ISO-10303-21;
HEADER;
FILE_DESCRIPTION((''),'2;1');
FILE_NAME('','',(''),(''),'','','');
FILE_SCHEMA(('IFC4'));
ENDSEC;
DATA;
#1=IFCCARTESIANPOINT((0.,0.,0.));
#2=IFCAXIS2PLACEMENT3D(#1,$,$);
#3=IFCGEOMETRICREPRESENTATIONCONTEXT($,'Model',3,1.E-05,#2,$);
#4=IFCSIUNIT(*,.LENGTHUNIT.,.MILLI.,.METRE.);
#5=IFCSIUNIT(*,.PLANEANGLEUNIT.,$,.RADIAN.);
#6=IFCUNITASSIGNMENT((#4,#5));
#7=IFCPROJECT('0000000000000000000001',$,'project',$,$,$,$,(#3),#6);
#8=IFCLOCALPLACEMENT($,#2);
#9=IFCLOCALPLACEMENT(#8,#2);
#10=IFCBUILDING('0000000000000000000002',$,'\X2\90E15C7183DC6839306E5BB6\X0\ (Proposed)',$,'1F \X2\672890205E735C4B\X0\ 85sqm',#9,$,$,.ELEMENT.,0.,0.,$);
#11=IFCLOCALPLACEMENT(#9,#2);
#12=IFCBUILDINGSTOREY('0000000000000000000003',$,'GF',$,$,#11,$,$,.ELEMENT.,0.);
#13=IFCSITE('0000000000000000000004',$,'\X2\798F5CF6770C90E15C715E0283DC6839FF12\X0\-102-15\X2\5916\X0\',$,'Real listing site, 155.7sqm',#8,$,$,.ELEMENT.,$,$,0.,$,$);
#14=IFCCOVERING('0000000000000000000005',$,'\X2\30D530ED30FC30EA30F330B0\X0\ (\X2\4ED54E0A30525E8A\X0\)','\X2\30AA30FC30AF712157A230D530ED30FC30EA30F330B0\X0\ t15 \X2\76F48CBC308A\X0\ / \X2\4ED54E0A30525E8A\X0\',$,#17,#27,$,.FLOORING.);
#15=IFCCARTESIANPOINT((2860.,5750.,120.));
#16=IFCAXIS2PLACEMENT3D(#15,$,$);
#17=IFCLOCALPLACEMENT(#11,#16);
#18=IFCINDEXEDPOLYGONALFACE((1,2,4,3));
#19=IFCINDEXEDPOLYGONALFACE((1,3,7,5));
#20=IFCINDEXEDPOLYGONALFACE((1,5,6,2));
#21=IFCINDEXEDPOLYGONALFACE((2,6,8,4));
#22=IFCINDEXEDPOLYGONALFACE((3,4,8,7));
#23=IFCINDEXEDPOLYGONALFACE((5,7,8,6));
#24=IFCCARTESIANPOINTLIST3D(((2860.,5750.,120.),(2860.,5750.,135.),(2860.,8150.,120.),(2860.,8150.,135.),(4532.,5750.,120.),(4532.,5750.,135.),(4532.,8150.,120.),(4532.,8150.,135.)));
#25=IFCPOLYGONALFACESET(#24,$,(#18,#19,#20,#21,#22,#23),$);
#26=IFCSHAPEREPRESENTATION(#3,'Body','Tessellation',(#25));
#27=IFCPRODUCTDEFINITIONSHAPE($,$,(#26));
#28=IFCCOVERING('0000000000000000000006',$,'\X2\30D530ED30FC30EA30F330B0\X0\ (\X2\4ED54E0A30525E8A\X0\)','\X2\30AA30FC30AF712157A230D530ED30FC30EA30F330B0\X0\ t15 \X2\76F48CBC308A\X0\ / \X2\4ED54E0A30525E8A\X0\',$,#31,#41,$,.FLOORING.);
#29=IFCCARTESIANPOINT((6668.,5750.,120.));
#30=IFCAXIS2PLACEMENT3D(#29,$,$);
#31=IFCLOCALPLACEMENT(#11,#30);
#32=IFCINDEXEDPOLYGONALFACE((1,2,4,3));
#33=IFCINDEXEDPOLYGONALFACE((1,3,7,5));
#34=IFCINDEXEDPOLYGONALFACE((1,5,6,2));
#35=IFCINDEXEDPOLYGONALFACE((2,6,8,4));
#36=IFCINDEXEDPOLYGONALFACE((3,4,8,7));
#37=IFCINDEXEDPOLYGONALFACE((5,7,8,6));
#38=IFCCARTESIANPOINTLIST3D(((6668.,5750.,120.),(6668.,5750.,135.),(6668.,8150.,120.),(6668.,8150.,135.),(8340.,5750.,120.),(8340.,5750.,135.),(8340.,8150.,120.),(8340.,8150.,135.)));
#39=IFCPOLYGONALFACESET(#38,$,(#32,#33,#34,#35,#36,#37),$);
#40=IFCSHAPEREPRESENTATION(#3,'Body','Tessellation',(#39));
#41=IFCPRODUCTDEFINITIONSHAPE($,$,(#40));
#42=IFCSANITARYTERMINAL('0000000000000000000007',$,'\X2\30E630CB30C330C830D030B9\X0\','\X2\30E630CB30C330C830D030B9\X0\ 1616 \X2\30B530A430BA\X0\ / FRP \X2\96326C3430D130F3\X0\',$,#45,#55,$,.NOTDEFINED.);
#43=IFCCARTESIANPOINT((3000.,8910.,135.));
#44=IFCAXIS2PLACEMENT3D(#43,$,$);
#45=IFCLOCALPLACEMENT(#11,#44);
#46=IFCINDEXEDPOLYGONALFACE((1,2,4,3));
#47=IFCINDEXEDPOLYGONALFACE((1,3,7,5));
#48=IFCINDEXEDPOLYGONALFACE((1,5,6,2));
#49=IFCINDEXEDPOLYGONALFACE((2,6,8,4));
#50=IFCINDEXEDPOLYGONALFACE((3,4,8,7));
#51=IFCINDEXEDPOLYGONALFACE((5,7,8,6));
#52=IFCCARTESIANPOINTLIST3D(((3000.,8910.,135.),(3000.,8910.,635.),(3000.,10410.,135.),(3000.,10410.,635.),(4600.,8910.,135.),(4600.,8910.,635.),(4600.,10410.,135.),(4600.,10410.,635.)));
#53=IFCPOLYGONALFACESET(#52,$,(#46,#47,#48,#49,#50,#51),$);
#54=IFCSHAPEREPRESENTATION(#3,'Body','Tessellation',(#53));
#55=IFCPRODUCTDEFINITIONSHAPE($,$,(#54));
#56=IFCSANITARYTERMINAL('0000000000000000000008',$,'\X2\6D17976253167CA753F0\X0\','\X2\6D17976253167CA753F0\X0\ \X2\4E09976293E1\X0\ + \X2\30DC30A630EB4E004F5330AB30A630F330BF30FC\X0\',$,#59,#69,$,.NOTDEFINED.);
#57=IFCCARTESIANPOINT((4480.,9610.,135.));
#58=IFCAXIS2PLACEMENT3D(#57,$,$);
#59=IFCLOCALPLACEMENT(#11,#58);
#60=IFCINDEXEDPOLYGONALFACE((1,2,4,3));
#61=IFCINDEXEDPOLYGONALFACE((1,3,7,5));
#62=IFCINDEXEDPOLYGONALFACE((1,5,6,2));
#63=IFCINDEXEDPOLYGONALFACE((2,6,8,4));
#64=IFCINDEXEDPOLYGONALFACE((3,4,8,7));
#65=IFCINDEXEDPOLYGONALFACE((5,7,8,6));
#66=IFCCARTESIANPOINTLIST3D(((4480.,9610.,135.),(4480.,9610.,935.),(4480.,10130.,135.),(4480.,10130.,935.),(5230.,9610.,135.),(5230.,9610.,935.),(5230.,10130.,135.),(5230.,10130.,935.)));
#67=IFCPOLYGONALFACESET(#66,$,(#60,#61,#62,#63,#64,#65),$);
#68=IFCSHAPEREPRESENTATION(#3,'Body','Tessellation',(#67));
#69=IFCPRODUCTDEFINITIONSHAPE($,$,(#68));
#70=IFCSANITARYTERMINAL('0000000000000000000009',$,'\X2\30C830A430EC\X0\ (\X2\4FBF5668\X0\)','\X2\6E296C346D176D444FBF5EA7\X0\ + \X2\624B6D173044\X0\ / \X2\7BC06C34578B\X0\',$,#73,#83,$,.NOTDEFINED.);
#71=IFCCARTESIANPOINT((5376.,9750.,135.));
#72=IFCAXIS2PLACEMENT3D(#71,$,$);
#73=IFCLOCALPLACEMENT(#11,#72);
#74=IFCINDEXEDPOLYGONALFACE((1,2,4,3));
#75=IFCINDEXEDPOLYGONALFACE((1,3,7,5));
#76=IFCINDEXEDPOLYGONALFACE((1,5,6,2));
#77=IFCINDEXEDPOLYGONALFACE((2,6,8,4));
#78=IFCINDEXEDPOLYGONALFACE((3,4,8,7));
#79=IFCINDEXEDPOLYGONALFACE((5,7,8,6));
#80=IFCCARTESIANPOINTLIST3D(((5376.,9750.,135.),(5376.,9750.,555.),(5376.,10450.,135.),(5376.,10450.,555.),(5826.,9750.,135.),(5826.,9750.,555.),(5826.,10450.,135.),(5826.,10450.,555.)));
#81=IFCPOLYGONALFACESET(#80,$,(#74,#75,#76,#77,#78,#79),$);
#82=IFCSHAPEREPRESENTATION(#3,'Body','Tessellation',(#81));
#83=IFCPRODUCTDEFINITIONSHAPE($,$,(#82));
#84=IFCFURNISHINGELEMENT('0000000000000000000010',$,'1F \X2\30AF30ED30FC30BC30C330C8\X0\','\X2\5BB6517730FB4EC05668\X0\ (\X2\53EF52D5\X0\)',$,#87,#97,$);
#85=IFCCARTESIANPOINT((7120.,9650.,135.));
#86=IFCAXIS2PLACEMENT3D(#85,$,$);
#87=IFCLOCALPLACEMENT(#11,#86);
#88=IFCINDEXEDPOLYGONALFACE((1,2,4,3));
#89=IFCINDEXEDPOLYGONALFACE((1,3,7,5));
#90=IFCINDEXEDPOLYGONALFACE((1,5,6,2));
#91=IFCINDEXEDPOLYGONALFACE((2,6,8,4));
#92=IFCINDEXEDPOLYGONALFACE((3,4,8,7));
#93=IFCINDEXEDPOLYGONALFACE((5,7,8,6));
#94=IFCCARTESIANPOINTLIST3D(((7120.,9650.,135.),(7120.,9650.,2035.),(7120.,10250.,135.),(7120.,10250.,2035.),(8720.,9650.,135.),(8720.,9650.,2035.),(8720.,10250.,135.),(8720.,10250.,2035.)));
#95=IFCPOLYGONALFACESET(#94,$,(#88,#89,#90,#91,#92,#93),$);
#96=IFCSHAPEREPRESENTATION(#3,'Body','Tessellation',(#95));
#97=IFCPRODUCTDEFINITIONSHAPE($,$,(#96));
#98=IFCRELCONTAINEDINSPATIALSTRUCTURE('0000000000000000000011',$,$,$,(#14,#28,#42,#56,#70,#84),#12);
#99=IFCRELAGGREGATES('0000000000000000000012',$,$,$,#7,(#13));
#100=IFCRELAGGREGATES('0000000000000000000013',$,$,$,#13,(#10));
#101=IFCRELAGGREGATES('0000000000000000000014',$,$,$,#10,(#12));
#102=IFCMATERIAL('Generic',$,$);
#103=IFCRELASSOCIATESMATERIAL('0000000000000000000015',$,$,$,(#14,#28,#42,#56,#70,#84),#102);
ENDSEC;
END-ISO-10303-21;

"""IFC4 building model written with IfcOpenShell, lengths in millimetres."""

from ifc_helpers import new_model, si_unit, frame, frame_2d, origin, place, context, project, spatial, rectangle, extrude, material, element, save


model = new_model("IFC4")

# Units and contexts
model_context = context("Model", 3, precision=1e-05, world=origin())
ifc_project = project(units=[si_unit("LENGTHUNIT", "METRE", prefix="MILLI"), si_unit("PLANEANGLEUNIT", "RADIAN")], contexts=[model_context])

# Site, building, storey
site_placement = place(None, origin())
site = spatial("IfcSite", under=ifc_project, at=site_placement, Name="福島県郡山市菜根２-102-15外", ObjectType="Real listing site, 155.7sqm", CompositionType="ELEMENT", RefElevation=0.0)
building_placement = place(site_placement, origin())
building = spatial("IfcBuilding", under=site, at=building_placement, Name="郡山菜根の家 (Proposed)", ObjectType="1F 木造平屋 85sqm", CompositionType="ELEMENT", ElevationOfRefHeight=0.0, ElevationOfTerrain=0.0)
storey_placement = place(building_placement, origin())
storey = spatial("IfcBuildingStorey", under=building, at=storey_placement, Name="GF", CompositionType="ELEMENT", Elevation=0.0)

# Coverings
ifc_material_1 = material(Name="Generic")
covering_1_placement = place(storey_placement, frame((2860.0, 5750.0, 120.0)))
element("IfcCovering", 1, at=covering_1_placement, inside=storey, material=ifc_material_1, Name="フローリング (仕上げ床)", Description="オーク無垢フローリング t15 直貼り / 仕上げ床", PredefinedType="FLOORING", context=model_context, shape_type="SweptSolid", body=[
    extrude(rectangle(XDim=1672.0, YDim=2400.0, at=frame_2d((836.0, 1200.0))), frame((2860.0, 5750.0, 120.0)), (0.0, 0.0, 1.0), 15.0),
])
covering_2_placement = place(storey_placement, frame((6668.0, 5750.0, 120.0)))
element("IfcCovering", 2, at=covering_2_placement, inside=storey, material=ifc_material_1, Name="フローリング (仕上げ床)", Description="オーク無垢フローリング t15 直貼り / 仕上げ床", PredefinedType="FLOORING", context=model_context, shape_type="SweptSolid", body=[
    extrude(rectangle(XDim=1672.0, YDim=2400.0, at=frame_2d((836.0, 1200.0))), frame((6668.0, 5750.0, 120.0)), (0.0, 0.0, 1.0), 15.0),
])

# Sanitary terminals
sanitary_terminal_1_placement = place(storey_placement, frame((3000.0, 8910.0, 135.0)))
element("IfcSanitaryTerminal", 3, at=sanitary_terminal_1_placement, inside=storey, material=ifc_material_1, Name="ユニットバス", Description="ユニットバス 1616 サイズ / FRP 防水パン", PredefinedType="NOTDEFINED", context=model_context, shape_type="SweptSolid", body=[
    extrude(rectangle(XDim=1600.0, YDim=1500.0, at=frame_2d((800.0, 750.0))), frame((3000.0, 8910.0, 135.0)), (0.0, 0.0, 1.0), 500.0),
])
sanitary_terminal_2_placement = place(storey_placement, frame((4480.0, 9610.0, 135.0)))
element("IfcSanitaryTerminal", 4, at=sanitary_terminal_2_placement, inside=storey, material=ifc_material_1, Name="洗面化粧台", Description="洗面化粧台 三面鏡 + ボウル一体カウンター", PredefinedType="NOTDEFINED", context=model_context, shape_type="SweptSolid", body=[
    extrude(rectangle(XDim=750.0, YDim=520.0, at=frame_2d((375.0, 260.0))), frame((4480.0, 9610.0, 135.0)), (0.0, 0.0, 1.0), 800.0),
])
sanitary_terminal_3_placement = place(storey_placement, frame((5376.0, 9750.0, 135.0)))
element("IfcSanitaryTerminal", 5, at=sanitary_terminal_3_placement, inside=storey, material=ifc_material_1, Name="トイレ (便器)", Description="温水洗浄便座 + 手洗い / 節水型", PredefinedType="NOTDEFINED", context=model_context, shape_type="SweptSolid", body=[
    extrude(rectangle(XDim=450.0, YDim=700.0, at=frame_2d((225.0, 350.0))), frame((5376.0, 9750.0, 135.0)), (0.0, 0.0, 1.0), 420.0),
])

# Furnishing element
furnishing_placement = place(storey_placement, frame((7120.0, 9650.0, 135.0)))
element("IfcFurnishingElement", 6, at=furnishing_placement, inside=storey, material=ifc_material_1, Name="1F クローゼット", Description="家具・什器 (可動)", context=model_context, shape_type="SweptSolid", body=[
    extrude(rectangle(XDim=1600.0, YDim=600.0, at=frame_2d((800.0, 300.0))), frame((7120.0, 9650.0, 135.0)), (0.0, 0.0, 1.0), 1900.0),
])

save(model, "model.ifc")
